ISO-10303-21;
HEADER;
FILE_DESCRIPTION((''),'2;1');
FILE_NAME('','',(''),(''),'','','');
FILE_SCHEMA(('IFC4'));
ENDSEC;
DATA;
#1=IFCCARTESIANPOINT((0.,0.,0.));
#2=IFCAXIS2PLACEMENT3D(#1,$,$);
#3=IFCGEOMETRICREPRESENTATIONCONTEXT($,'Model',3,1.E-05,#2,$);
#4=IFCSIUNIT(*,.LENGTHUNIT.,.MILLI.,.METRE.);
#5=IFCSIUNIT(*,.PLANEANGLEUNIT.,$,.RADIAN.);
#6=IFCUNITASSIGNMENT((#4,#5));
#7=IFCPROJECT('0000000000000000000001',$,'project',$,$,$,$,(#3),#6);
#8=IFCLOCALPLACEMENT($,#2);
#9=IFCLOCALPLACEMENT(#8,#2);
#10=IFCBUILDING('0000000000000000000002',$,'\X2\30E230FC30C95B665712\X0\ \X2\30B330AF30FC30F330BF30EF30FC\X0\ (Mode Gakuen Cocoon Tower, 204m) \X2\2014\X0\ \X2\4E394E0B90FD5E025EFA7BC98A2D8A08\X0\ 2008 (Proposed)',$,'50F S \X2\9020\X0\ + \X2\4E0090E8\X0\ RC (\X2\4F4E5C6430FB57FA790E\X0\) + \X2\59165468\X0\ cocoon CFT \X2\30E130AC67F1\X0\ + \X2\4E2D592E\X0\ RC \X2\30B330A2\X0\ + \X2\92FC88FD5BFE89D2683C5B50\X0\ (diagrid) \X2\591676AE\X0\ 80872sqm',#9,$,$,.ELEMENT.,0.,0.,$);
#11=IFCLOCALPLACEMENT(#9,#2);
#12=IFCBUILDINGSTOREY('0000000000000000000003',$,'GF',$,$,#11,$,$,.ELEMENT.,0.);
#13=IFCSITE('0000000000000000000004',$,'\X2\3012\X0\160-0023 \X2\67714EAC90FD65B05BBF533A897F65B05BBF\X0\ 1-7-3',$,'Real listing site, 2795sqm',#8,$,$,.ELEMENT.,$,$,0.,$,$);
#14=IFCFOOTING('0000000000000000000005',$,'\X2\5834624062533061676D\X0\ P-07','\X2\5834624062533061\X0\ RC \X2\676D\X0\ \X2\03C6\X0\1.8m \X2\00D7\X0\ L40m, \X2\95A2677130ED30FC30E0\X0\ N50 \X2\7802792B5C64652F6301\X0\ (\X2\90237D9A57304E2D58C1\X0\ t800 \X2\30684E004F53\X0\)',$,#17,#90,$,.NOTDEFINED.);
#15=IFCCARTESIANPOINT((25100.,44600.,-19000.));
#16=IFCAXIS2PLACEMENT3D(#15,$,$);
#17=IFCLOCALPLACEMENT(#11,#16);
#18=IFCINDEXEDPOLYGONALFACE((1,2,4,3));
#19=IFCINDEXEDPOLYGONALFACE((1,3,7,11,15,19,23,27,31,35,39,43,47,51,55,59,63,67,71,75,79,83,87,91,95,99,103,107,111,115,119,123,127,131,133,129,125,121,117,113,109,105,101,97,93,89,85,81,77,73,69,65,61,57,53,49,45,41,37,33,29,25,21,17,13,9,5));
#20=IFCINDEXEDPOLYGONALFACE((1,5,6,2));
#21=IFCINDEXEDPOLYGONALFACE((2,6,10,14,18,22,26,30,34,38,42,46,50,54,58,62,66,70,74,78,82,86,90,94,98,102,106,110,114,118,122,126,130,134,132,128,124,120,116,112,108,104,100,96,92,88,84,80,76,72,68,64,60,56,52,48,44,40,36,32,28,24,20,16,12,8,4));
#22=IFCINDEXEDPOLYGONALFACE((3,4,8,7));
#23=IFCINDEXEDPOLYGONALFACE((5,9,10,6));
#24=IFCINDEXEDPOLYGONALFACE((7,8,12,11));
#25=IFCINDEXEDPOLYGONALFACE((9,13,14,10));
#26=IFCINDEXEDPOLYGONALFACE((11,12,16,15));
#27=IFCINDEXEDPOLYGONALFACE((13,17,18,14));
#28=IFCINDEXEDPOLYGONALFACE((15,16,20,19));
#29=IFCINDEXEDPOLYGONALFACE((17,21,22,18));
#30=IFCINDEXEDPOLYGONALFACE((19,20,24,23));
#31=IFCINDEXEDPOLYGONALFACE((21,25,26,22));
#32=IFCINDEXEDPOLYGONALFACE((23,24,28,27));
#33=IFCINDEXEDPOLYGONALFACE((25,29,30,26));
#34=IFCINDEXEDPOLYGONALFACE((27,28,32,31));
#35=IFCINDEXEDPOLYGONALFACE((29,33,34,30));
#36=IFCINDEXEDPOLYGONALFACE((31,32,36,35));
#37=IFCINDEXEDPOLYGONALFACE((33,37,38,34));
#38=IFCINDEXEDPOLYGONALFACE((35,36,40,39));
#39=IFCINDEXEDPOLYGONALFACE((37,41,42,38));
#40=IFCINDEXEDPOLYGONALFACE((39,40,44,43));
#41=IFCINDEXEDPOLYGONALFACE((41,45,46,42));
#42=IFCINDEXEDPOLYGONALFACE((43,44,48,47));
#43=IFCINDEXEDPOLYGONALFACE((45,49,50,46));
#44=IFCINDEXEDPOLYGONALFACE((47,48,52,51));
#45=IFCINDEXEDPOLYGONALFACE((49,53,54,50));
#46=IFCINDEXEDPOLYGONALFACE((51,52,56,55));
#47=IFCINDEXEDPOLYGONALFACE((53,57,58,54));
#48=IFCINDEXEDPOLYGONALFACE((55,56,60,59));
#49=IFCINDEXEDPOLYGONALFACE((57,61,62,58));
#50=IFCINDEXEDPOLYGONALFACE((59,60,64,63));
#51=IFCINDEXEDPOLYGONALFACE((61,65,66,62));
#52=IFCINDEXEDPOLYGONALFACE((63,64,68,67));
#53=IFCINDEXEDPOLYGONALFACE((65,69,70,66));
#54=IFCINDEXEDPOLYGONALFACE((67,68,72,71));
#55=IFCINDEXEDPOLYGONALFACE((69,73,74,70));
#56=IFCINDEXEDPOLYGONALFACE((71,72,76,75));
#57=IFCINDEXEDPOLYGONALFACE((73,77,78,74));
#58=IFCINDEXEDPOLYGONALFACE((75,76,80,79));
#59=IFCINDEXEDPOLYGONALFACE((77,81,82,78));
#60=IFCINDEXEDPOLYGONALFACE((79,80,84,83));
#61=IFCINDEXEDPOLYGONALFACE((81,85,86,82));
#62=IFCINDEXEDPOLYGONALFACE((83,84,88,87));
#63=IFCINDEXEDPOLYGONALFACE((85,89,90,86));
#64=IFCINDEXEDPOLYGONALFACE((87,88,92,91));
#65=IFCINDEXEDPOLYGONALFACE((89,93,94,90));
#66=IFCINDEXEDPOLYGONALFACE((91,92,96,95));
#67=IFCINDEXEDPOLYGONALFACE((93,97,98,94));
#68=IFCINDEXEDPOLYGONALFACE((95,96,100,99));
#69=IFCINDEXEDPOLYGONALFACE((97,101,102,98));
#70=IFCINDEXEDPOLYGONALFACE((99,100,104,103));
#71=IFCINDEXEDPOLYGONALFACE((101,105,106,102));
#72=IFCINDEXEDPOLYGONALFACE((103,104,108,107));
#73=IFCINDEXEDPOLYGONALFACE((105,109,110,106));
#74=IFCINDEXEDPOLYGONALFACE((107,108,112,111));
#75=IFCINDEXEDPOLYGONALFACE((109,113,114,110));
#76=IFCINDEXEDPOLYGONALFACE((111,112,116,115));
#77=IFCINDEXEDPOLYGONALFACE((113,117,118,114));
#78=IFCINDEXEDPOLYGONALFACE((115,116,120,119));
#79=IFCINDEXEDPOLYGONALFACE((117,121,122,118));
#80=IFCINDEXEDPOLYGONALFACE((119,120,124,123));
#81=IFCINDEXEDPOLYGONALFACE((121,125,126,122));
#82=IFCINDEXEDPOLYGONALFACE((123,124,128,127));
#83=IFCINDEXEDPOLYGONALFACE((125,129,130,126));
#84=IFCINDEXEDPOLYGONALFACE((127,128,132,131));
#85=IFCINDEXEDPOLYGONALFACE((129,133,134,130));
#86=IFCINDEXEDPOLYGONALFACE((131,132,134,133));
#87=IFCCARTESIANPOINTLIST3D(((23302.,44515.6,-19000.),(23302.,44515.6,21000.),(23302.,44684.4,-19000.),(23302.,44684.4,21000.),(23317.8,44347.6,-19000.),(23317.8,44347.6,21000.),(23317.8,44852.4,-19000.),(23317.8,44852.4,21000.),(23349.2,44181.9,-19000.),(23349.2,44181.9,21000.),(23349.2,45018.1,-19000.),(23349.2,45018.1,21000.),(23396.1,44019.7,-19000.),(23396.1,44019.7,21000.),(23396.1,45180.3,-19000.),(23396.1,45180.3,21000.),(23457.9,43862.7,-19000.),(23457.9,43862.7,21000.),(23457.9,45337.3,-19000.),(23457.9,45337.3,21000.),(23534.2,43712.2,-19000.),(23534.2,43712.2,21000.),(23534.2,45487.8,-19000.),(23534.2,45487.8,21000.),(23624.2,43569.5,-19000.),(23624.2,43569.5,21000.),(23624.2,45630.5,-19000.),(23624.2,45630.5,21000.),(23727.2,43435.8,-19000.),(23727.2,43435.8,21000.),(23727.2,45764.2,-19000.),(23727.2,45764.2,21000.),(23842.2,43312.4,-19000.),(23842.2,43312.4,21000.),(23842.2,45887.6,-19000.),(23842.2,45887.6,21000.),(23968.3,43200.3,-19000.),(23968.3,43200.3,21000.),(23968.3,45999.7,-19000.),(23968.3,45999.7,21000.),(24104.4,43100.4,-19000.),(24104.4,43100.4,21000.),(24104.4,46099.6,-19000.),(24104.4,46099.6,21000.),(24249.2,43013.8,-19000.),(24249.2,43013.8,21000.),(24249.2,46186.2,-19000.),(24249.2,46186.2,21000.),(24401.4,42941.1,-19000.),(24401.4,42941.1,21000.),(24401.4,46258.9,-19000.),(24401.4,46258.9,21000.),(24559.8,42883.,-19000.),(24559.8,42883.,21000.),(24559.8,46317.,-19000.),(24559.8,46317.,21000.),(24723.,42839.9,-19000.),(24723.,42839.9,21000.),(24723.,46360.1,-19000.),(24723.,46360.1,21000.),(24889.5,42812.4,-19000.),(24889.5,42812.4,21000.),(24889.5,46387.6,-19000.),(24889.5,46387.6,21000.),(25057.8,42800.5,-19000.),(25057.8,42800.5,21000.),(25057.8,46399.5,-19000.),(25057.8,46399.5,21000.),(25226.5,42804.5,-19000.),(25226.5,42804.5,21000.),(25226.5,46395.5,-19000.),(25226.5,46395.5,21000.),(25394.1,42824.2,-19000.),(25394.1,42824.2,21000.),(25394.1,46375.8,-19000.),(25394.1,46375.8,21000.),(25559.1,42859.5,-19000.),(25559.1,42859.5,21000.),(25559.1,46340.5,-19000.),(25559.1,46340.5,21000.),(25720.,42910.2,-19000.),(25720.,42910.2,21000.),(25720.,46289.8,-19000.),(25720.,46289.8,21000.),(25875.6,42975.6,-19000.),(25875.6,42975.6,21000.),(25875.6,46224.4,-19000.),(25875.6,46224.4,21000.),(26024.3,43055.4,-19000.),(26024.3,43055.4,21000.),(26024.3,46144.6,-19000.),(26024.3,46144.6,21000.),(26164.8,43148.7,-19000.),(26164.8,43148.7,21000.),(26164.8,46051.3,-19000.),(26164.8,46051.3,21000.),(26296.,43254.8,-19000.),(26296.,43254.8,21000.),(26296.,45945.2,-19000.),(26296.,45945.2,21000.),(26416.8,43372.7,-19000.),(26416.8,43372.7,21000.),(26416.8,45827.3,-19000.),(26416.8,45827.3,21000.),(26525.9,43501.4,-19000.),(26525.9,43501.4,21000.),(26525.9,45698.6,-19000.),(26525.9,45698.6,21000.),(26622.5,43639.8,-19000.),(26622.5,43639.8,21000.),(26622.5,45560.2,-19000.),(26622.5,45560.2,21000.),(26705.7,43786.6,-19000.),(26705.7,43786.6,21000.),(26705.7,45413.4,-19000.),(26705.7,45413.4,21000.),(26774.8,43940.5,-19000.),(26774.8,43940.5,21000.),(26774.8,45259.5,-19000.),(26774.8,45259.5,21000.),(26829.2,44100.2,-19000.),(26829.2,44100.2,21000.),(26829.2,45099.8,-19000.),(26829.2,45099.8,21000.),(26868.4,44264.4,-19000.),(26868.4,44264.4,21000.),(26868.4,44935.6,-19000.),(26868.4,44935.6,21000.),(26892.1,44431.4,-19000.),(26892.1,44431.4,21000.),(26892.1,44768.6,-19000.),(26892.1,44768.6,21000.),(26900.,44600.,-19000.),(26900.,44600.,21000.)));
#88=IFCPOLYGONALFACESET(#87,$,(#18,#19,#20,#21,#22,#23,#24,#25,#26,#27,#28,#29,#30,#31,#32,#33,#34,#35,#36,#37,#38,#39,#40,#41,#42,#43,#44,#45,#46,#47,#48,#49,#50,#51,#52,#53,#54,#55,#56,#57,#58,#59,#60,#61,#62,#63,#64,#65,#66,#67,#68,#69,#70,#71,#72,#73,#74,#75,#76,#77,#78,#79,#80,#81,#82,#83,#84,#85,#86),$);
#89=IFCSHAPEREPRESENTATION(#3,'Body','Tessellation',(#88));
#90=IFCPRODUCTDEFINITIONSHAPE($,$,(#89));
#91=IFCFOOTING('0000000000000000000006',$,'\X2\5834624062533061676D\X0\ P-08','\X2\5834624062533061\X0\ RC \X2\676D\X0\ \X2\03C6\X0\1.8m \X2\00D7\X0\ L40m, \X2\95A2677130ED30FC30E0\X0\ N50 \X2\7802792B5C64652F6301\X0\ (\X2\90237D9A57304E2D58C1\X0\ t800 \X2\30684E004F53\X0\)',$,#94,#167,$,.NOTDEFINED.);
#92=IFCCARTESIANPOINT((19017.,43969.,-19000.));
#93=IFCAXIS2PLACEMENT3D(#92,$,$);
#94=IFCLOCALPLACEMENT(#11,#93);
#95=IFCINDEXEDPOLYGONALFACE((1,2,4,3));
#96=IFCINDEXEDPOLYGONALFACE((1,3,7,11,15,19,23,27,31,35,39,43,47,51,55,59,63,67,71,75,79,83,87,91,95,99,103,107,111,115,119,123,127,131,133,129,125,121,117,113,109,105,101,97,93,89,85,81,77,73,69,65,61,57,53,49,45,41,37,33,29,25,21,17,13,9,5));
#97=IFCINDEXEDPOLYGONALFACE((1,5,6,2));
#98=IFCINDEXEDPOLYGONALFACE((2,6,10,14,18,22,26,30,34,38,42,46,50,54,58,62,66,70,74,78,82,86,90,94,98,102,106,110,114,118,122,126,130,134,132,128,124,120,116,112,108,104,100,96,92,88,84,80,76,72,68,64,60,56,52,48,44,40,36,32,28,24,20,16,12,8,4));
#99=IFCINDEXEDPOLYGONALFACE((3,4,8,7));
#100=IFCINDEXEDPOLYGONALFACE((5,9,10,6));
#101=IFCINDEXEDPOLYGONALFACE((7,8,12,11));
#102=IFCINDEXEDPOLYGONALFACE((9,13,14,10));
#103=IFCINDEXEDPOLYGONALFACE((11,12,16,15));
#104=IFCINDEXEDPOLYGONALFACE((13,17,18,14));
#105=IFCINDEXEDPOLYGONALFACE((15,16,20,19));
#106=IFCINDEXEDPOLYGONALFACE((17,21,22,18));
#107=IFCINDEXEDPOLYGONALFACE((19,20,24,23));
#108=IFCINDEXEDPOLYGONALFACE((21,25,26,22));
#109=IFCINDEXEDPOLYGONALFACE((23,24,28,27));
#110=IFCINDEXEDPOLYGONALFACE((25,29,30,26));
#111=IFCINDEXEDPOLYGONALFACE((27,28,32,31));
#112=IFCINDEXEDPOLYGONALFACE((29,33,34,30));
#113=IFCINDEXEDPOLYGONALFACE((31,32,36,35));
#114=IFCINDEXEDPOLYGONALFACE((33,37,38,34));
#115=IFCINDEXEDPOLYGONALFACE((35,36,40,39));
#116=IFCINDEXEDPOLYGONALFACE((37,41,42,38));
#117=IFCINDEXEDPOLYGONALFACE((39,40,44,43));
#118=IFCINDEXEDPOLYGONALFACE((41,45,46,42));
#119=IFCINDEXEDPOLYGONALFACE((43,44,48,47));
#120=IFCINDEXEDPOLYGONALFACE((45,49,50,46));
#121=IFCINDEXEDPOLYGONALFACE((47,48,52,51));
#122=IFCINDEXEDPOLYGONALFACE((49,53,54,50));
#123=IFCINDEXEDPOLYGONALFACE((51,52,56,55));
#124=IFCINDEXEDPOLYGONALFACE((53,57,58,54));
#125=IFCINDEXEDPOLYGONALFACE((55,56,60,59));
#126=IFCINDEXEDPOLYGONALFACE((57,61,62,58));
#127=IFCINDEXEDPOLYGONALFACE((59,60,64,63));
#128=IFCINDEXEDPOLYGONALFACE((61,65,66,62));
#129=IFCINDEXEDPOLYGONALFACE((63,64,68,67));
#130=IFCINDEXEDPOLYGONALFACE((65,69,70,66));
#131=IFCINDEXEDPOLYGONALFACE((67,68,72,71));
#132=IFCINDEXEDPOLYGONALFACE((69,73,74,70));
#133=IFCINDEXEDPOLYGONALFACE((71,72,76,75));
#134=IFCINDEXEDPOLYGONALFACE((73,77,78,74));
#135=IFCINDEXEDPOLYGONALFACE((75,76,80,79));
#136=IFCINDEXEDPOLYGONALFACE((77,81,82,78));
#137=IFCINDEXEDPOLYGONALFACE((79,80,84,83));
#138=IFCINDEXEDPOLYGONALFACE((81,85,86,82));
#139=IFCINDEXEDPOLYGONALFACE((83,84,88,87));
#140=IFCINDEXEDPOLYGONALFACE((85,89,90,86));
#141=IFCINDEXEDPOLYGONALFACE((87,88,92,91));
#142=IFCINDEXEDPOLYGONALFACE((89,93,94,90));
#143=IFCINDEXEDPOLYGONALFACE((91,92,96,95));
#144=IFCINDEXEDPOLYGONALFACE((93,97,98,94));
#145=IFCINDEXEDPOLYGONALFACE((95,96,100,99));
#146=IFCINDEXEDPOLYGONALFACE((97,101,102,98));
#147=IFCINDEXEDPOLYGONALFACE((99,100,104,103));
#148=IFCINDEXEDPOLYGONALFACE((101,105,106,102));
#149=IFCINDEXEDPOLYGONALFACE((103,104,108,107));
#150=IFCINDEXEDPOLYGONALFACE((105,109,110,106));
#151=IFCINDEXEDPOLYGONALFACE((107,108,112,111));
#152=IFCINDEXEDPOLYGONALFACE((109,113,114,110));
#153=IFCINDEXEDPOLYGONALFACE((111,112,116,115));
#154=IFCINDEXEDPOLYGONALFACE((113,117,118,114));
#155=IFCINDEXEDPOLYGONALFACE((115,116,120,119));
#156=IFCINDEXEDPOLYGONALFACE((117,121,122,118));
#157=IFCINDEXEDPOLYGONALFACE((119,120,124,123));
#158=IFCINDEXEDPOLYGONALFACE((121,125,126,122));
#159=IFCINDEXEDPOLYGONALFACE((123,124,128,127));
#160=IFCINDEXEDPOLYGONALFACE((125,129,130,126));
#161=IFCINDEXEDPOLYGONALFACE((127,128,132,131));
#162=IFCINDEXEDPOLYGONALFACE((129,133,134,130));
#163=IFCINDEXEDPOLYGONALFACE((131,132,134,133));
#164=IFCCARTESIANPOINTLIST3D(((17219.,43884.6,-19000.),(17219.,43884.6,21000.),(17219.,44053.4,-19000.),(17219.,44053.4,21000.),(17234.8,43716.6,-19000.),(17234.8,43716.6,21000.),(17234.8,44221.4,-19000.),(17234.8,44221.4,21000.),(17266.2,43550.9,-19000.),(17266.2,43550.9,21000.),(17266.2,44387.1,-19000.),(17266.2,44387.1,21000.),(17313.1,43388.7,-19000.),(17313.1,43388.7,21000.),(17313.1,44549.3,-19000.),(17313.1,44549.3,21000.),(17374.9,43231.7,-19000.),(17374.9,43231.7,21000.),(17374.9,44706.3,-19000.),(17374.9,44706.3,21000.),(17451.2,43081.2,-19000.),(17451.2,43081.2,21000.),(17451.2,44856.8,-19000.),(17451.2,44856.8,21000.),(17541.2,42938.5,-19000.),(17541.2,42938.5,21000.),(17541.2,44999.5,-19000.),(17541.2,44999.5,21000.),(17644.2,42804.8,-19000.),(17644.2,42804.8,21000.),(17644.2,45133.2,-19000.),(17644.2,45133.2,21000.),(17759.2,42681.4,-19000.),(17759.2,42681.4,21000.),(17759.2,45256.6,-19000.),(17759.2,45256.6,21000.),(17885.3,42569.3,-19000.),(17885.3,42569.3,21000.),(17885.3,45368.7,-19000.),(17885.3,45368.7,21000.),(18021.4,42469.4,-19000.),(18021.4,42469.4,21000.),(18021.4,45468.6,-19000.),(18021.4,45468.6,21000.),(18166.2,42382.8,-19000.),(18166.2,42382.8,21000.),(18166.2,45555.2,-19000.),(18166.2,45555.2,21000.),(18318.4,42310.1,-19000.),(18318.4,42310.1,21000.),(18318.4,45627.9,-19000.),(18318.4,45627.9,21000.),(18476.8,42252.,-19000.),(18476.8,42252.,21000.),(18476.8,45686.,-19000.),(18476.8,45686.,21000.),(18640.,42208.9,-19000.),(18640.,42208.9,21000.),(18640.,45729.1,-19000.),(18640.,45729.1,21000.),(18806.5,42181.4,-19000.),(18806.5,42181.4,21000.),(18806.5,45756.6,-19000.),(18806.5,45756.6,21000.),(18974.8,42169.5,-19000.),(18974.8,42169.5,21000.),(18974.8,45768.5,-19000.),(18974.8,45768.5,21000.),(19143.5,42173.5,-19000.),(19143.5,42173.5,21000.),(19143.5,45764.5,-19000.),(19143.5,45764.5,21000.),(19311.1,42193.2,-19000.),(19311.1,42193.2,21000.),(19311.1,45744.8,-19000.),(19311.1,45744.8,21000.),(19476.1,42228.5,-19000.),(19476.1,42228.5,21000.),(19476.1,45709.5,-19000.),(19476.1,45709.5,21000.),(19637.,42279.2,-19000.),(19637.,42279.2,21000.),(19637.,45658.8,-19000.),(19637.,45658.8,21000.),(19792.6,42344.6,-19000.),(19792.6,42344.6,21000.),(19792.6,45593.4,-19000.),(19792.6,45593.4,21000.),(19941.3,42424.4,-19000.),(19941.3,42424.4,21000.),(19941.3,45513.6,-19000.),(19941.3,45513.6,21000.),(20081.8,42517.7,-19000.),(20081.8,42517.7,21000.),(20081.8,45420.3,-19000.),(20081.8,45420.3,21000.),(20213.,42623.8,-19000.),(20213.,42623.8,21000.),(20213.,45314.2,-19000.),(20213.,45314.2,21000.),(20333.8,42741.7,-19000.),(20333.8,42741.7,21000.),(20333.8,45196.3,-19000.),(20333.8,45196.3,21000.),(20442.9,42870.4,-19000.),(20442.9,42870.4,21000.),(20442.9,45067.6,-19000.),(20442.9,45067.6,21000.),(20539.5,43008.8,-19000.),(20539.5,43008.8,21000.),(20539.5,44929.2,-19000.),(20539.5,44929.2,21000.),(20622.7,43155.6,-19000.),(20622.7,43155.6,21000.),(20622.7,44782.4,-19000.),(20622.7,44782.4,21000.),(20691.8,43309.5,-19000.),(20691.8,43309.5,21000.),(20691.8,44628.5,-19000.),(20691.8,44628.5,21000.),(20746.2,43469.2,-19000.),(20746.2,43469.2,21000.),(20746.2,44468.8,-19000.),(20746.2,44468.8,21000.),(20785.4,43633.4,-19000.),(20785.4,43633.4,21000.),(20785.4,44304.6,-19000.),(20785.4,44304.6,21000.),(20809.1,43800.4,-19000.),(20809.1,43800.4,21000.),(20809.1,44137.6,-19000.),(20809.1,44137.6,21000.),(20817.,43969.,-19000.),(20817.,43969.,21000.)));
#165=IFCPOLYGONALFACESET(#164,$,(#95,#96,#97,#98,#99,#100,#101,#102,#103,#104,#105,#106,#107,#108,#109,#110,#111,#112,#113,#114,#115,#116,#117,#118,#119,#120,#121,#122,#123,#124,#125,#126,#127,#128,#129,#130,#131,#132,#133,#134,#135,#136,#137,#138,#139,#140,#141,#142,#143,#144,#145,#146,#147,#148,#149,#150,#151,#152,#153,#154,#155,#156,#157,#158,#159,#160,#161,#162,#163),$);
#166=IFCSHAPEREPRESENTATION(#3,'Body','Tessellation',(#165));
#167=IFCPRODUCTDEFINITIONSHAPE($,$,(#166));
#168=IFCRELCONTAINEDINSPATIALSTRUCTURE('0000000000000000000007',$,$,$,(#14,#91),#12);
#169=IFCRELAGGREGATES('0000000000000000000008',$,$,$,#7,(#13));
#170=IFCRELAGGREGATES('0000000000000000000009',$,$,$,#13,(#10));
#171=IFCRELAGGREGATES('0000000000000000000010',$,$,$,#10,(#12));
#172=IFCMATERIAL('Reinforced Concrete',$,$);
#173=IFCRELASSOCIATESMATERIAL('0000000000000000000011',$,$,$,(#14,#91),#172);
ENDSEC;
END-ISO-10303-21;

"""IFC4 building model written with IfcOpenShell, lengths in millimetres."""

from ifc_helpers import new_model, si_unit, frame, origin, origin_2d, place, context, project, spatial, circle, extrude, material, element, save


model = new_model("IFC4")

# Units and contexts
model_context = context("Model", 3, precision=1e-05, world=origin())
ifc_project = project(units=[si_unit("LENGTHUNIT", "METRE", prefix="MILLI"), si_unit("PLANEANGLEUNIT", "RADIAN")], contexts=[model_context])

# Site, building, storey
site_placement = place(None, origin())
site = spatial("IfcSite", under=ifc_project, at=site_placement, Name="〒160-0023 東京都新宿区西新宿 1-7-3", ObjectType="Real listing site, 2795sqm", CompositionType="ELEMENT", RefElevation=0.0)
building_placement = place(site_placement, origin())
building = spatial("IfcBuilding", under=site, at=building_placement, Name="モード学園 コクーンタワー (Mode Gakuen Cocoon Tower, 204m) — 丹下都市建築設計 2008 (Proposed)", ObjectType="50F S 造 + 一部 RC (低層・基礎) + 外周 cocoon CFT メガ柱 + 中央 RC コア + 鋼製対角格子 (diagrid) 外皮 80872sqm", CompositionType="ELEMENT", ElevationOfRefHeight=0.0, ElevationOfTerrain=0.0)
storey_placement = place(building_placement, origin())
storey = spatial("IfcBuildingStorey", under=building, at=storey_placement, Name="GF", CompositionType="ELEMENT", Elevation=0.0)

# Footings
ifc_material_1 = material(Name="Reinforced Concrete")
footing_1_placement = place(storey_placement, frame((25100.0, 44600.0, -19000.0)))
element("IfcFooting", 1, at=footing_1_placement, inside=storey, material=ifc_material_1, Name="場所打ち杭 P-07", Description="場所打ち RC 杭 φ1.8m × L40m, 関東ローム N50 砂礫層支持 (連続地中壁 t800 と一体)", PredefinedType="NOTDEFINED", context=model_context, shape_type="SweptSolid", body=[
    extrude(circle(Radius=1800.0, at=origin_2d()), frame((25100.0, 44600.0, -19000.0)), (0.0, 0.0, 1.0), 40000.0),
])
footing_2_placement = place(storey_placement, frame((19017.0, 43969.0, -19000.0)))
element("IfcFooting", 2, at=footing_2_placement, inside=storey, material=ifc_material_1, Name="場所打ち杭 P-08", Description="場所打ち RC 杭 φ1.8m × L40m, 関東ローム N50 砂礫層支持 (連続地中壁 t800 と一体)", PredefinedType="NOTDEFINED", context=model_context, shape_type="SweptSolid", body=[
    extrude(circle(Radius=1800.0, at=origin_2d()), frame((19017.0, 43969.0, -19000.0)), (0.0, 0.0, 1.0), 40000.0),
])

save(model, "model.ifc")
